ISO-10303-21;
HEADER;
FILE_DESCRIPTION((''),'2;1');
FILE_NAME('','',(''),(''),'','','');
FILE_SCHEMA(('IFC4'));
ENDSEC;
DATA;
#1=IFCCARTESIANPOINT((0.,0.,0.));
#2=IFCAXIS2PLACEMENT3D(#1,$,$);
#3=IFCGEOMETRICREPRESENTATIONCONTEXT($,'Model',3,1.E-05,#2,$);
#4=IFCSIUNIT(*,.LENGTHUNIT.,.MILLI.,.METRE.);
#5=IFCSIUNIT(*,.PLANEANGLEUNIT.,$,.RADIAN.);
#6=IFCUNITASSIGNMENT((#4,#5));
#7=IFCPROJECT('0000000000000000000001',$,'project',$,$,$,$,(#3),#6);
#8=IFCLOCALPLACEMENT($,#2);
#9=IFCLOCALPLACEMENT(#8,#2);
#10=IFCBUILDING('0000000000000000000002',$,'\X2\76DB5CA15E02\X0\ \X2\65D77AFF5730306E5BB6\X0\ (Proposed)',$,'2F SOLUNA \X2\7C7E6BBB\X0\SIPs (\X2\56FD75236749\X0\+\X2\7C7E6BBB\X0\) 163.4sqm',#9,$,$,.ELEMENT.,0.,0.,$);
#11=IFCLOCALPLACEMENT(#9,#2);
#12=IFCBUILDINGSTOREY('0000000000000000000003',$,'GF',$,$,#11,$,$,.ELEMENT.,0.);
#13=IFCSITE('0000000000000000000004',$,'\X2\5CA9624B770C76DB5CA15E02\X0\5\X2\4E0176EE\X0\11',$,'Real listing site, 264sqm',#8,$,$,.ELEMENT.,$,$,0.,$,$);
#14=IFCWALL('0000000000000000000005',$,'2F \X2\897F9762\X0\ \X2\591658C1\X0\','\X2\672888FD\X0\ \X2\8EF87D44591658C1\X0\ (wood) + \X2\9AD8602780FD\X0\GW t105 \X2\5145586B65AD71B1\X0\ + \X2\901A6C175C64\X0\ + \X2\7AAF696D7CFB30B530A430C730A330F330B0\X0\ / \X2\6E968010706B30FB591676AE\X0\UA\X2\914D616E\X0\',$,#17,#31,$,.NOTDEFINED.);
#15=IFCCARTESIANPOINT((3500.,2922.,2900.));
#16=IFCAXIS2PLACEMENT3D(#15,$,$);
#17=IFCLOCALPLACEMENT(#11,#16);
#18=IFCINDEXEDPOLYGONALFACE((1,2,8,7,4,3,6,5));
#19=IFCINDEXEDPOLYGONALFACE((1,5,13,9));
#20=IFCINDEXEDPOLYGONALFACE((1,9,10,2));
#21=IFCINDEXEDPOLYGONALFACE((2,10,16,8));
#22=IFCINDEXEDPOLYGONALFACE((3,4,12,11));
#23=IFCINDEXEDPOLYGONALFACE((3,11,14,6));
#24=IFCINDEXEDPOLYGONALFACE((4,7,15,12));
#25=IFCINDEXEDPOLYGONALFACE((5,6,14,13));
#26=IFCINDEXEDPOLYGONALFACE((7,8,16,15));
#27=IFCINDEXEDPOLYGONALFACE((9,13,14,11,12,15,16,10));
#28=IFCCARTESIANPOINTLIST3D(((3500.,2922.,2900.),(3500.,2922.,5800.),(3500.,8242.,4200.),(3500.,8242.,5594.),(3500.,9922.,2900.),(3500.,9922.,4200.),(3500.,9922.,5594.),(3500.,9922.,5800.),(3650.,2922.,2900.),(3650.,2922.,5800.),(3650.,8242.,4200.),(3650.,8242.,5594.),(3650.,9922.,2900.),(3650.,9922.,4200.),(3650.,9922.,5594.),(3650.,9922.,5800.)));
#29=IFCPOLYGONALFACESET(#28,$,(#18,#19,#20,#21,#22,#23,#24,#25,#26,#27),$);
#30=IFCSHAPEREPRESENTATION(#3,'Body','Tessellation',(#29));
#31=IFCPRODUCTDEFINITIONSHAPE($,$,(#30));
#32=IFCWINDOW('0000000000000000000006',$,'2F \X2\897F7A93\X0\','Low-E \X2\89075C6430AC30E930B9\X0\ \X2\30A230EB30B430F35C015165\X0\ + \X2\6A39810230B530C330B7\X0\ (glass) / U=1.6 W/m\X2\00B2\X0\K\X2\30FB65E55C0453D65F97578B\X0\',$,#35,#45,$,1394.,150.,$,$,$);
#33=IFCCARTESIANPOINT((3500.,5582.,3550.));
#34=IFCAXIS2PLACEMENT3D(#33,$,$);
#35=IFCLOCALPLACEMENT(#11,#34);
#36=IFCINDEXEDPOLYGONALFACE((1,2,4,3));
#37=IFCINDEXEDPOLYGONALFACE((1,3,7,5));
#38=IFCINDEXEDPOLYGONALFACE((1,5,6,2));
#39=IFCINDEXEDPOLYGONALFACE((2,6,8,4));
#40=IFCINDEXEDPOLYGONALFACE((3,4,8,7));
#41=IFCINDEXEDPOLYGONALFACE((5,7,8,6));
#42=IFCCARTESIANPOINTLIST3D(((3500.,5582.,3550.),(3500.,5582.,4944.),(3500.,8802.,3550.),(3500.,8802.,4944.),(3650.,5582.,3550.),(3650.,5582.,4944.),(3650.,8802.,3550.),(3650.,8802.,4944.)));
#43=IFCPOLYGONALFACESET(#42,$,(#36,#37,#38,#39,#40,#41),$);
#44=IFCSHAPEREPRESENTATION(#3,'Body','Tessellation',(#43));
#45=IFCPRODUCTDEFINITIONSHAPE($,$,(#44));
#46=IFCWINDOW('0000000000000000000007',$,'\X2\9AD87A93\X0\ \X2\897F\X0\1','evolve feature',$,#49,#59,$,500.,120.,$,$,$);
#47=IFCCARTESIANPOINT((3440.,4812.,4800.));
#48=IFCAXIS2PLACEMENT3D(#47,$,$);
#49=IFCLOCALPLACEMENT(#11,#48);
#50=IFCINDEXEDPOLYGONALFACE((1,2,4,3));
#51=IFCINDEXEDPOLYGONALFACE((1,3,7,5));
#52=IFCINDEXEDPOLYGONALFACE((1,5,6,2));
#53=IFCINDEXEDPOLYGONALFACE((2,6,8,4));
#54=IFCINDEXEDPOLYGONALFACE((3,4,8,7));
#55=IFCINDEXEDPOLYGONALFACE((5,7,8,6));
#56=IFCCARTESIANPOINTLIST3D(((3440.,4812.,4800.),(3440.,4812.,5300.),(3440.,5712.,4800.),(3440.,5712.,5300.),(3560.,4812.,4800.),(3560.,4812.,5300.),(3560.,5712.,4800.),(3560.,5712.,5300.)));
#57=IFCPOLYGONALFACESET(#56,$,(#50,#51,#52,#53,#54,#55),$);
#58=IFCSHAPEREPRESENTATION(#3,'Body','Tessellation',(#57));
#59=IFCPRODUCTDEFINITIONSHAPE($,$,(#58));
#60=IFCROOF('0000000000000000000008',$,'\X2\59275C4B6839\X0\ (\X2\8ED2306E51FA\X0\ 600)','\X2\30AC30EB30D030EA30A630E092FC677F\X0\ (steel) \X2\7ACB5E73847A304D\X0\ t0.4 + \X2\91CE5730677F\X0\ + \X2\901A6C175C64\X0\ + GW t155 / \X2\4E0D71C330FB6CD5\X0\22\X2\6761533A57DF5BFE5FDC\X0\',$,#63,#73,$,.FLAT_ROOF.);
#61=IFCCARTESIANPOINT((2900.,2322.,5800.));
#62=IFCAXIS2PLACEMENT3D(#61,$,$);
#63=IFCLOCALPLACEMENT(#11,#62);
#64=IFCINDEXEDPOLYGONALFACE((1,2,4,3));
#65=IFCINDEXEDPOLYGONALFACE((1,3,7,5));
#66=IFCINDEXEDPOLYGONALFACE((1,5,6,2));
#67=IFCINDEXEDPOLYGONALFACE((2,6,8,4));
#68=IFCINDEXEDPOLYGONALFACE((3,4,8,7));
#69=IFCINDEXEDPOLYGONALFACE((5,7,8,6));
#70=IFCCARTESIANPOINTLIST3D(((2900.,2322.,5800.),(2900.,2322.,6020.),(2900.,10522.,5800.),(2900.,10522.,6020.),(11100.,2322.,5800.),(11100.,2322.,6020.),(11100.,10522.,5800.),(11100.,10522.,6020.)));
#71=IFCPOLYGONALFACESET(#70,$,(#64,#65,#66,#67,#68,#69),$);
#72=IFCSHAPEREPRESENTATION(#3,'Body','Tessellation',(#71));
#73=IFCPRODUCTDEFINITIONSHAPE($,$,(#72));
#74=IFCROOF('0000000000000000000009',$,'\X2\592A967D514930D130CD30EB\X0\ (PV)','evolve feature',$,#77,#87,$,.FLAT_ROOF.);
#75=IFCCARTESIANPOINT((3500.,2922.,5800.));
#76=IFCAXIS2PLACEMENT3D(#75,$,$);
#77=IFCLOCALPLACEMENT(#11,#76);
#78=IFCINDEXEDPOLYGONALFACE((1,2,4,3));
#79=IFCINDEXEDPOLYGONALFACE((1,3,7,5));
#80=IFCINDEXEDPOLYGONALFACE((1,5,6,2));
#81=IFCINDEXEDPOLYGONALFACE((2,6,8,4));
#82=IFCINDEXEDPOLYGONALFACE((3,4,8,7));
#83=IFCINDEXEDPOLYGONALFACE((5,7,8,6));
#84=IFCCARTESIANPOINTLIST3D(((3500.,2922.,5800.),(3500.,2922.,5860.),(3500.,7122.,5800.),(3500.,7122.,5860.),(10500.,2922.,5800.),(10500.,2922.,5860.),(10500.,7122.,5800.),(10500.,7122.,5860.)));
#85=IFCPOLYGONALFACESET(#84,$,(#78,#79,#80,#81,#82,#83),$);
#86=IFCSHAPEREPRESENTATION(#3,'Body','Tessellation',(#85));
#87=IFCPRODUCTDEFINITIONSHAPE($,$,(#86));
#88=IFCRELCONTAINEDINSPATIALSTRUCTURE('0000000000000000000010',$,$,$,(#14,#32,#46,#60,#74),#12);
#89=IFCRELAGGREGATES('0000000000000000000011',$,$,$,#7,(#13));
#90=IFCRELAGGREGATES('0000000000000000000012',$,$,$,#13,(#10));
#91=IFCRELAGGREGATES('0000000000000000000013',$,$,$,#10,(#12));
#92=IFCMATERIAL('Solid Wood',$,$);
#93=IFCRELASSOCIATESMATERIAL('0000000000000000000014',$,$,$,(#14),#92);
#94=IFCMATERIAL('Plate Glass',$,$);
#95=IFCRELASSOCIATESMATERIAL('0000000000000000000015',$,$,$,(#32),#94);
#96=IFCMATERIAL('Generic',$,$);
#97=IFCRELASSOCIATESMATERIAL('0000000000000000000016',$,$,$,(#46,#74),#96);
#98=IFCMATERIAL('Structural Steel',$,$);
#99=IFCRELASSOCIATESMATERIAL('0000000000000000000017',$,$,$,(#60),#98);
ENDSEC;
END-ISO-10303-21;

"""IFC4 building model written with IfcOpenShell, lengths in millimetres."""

from ifc_helpers import new_model, si_unit, frame, frame_2d, origin, place, context, project, spatial, rectangle, extrude, material, element, fill, save


model = new_model("IFC4")

# Units and contexts
model_context = context("Model", 3, precision=1e-05, world=origin())
ifc_project = project(units=[si_unit("LENGTHUNIT", "METRE", prefix="MILLI"), si_unit("PLANEANGLEUNIT", "RADIAN")], contexts=[model_context])

# Site, building, storey
site_placement = place(None, origin())
site = spatial("IfcSite", under=ifc_project, at=site_placement, Name="岩手県盛岡市5丁目11", ObjectType="Real listing site, 264sqm", CompositionType="ELEMENT", RefElevation=0.0)
building_placement = place(site_placement, origin())
building = spatial("IfcBuilding", under=site, at=building_placement, Name="盛岡市 旗竿地の家 (Proposed)", ObjectType="2F SOLUNA 籾殻SIPs (国産杉+籾殻) 163.4sqm", CompositionType="ELEMENT", ElevationOfRefHeight=0.0, ElevationOfTerrain=0.0)
storey_placement = place(building_placement, origin())
storey = spatial("IfcBuildingStorey", under=building, at=storey_placement, Name="GF", CompositionType="ELEMENT", Elevation=0.0)

# Shared definitions
ifc_material_1 = material(Name="Solid Wood")
ifc_material_2 = material(Name="Generic")

# Shared definitions
ifc_material_3 = material(Name="Plate Glass")

# Wall, openings, windows
wall_1_placement = place(storey_placement, frame((3500.0, 2922.0, 2900.0)))
wall_1 = element("IfcWall", 1, at=wall_1_placement, inside=storey, material=ifc_material_1, Name="2F 西面 外壁", Description="木製 軸組外壁 (wood) + 高性能GW t105 充填断熱 + 通気層 + 窯業系サイディング / 準耐火・外皮UA配慮", PredefinedType="NOTDEFINED", context=model_context, shape_type="SweptSolid", body=[
    extrude(rectangle(XDim=150.0, YDim=7000.0, at=frame_2d((75.0, 3500.0))), frame((3500.0, 2922.0, 2900.0)), (0.0, 0.0, 1.0), 2900.0),
])
opening_1_placement = place(storey_placement, frame((3500.0, 5582.0, 3550.0)))
opening_1 = element("IfcOpeningElement", 2, at=opening_1_placement, cuts=wall_1, PredefinedType="NOTDEFINED", context=model_context, shape_type="SweptSolid", body=[
    extrude(rectangle(XDim=150.0, YDim=3220.0, at=frame_2d((75.0, 1610.0))), frame((3500.0, 5582.0, 3550.0)), (0.0, 0.0, 1.0), 1394.0),
])
opening_2_placement = place(storey_placement, frame((3440.0, 4812.0, 4800.0)))
opening_2 = element("IfcOpeningElement", 3, at=opening_2_placement, cuts=wall_1, PredefinedType="NOTDEFINED", context=model_context, shape_type="SweptSolid", body=[
    extrude(rectangle(XDim=120.0, YDim=900.0, at=frame_2d((60.0, 450.0))), frame((3440.0, 4812.0, 4800.0)), (0.0, 0.0, 1.0), 500.0),
])
window_1_placement = place(storey_placement, frame((3500.0, 5582.0, 3550.0)))
window_1 = element("IfcWindow", 4, at=window_1_placement, inside=storey, material=ifc_material_3, Name="2F 西窓", Description="Low-E 複層ガラス アルゴン封入 + 樹脂サッシ (glass) / U=1.6 W/m²K・日射取得型", OverallHeight=1394.0, OverallWidth=150.0, context=model_context, shape_type="SweptSolid", body=[
    extrude(rectangle(XDim=150.0, YDim=3220.0, at=frame_2d((75.0, 1610.0))), frame((3500.0, 5582.0, 3550.0)), (0.0, 0.0, 1.0), 1394.0),
])
fill(opening_1, window_1)
window_2_placement = place(storey_placement, frame((3440.0, 4812.0, 4800.0)))
window_2 = element("IfcWindow", 5, at=window_2_placement, inside=storey, material=ifc_material_2, Name="高窓 西1", Description="evolve feature", OverallHeight=500.0, OverallWidth=120.0, context=model_context, shape_type="SweptSolid", body=[
    extrude(rectangle(XDim=120.0, YDim=900.0, at=frame_2d((60.0, 450.0))), frame((3440.0, 4812.0, 4800.0)), (0.0, 0.0, 1.0), 500.0),
])
fill(opening_2, window_2)

# Roofs
ifc_material_4 = material(Name="Structural Steel")
roof_1_placement = place(storey_placement, frame((2900.0, 2322.0, 5800.0)))
element("IfcRoof", 6, at=roof_1_placement, inside=storey, material=ifc_material_4, Name="大屋根 (軒の出 600)", Description="ガルバリウム鋼板 (steel) 立平葺き t0.4 + 野地板 + 通気層 + GW t155 / 不燃・法22条区域対応", PredefinedType="FLAT_ROOF", context=model_context, shape_type="SweptSolid", body=[
    extrude(rectangle(XDim=8200.0, YDim=8200.0, at=frame_2d((4100.0, 4100.0))), frame((2900.0, 2322.0, 5800.0)), (0.0, 0.0, 1.0), 220.0),
])
roof_2_placement = place(storey_placement, frame((3500.0, 2922.0, 5800.0)))
element("IfcRoof", 7, at=roof_2_placement, inside=storey, material=ifc_material_2, Name="太陽光パネル (PV)", Description="evolve feature", PredefinedType="FLAT_ROOF", context=model_context, shape_type="SweptSolid", body=[
    extrude(rectangle(XDim=7000.0, YDim=4200.0, at=frame_2d((3500.0, 2100.0))), frame((3500.0, 2922.0, 5800.0)), (0.0, 0.0, 1.0), 60.0),
])

save(model, "model.ifc")
